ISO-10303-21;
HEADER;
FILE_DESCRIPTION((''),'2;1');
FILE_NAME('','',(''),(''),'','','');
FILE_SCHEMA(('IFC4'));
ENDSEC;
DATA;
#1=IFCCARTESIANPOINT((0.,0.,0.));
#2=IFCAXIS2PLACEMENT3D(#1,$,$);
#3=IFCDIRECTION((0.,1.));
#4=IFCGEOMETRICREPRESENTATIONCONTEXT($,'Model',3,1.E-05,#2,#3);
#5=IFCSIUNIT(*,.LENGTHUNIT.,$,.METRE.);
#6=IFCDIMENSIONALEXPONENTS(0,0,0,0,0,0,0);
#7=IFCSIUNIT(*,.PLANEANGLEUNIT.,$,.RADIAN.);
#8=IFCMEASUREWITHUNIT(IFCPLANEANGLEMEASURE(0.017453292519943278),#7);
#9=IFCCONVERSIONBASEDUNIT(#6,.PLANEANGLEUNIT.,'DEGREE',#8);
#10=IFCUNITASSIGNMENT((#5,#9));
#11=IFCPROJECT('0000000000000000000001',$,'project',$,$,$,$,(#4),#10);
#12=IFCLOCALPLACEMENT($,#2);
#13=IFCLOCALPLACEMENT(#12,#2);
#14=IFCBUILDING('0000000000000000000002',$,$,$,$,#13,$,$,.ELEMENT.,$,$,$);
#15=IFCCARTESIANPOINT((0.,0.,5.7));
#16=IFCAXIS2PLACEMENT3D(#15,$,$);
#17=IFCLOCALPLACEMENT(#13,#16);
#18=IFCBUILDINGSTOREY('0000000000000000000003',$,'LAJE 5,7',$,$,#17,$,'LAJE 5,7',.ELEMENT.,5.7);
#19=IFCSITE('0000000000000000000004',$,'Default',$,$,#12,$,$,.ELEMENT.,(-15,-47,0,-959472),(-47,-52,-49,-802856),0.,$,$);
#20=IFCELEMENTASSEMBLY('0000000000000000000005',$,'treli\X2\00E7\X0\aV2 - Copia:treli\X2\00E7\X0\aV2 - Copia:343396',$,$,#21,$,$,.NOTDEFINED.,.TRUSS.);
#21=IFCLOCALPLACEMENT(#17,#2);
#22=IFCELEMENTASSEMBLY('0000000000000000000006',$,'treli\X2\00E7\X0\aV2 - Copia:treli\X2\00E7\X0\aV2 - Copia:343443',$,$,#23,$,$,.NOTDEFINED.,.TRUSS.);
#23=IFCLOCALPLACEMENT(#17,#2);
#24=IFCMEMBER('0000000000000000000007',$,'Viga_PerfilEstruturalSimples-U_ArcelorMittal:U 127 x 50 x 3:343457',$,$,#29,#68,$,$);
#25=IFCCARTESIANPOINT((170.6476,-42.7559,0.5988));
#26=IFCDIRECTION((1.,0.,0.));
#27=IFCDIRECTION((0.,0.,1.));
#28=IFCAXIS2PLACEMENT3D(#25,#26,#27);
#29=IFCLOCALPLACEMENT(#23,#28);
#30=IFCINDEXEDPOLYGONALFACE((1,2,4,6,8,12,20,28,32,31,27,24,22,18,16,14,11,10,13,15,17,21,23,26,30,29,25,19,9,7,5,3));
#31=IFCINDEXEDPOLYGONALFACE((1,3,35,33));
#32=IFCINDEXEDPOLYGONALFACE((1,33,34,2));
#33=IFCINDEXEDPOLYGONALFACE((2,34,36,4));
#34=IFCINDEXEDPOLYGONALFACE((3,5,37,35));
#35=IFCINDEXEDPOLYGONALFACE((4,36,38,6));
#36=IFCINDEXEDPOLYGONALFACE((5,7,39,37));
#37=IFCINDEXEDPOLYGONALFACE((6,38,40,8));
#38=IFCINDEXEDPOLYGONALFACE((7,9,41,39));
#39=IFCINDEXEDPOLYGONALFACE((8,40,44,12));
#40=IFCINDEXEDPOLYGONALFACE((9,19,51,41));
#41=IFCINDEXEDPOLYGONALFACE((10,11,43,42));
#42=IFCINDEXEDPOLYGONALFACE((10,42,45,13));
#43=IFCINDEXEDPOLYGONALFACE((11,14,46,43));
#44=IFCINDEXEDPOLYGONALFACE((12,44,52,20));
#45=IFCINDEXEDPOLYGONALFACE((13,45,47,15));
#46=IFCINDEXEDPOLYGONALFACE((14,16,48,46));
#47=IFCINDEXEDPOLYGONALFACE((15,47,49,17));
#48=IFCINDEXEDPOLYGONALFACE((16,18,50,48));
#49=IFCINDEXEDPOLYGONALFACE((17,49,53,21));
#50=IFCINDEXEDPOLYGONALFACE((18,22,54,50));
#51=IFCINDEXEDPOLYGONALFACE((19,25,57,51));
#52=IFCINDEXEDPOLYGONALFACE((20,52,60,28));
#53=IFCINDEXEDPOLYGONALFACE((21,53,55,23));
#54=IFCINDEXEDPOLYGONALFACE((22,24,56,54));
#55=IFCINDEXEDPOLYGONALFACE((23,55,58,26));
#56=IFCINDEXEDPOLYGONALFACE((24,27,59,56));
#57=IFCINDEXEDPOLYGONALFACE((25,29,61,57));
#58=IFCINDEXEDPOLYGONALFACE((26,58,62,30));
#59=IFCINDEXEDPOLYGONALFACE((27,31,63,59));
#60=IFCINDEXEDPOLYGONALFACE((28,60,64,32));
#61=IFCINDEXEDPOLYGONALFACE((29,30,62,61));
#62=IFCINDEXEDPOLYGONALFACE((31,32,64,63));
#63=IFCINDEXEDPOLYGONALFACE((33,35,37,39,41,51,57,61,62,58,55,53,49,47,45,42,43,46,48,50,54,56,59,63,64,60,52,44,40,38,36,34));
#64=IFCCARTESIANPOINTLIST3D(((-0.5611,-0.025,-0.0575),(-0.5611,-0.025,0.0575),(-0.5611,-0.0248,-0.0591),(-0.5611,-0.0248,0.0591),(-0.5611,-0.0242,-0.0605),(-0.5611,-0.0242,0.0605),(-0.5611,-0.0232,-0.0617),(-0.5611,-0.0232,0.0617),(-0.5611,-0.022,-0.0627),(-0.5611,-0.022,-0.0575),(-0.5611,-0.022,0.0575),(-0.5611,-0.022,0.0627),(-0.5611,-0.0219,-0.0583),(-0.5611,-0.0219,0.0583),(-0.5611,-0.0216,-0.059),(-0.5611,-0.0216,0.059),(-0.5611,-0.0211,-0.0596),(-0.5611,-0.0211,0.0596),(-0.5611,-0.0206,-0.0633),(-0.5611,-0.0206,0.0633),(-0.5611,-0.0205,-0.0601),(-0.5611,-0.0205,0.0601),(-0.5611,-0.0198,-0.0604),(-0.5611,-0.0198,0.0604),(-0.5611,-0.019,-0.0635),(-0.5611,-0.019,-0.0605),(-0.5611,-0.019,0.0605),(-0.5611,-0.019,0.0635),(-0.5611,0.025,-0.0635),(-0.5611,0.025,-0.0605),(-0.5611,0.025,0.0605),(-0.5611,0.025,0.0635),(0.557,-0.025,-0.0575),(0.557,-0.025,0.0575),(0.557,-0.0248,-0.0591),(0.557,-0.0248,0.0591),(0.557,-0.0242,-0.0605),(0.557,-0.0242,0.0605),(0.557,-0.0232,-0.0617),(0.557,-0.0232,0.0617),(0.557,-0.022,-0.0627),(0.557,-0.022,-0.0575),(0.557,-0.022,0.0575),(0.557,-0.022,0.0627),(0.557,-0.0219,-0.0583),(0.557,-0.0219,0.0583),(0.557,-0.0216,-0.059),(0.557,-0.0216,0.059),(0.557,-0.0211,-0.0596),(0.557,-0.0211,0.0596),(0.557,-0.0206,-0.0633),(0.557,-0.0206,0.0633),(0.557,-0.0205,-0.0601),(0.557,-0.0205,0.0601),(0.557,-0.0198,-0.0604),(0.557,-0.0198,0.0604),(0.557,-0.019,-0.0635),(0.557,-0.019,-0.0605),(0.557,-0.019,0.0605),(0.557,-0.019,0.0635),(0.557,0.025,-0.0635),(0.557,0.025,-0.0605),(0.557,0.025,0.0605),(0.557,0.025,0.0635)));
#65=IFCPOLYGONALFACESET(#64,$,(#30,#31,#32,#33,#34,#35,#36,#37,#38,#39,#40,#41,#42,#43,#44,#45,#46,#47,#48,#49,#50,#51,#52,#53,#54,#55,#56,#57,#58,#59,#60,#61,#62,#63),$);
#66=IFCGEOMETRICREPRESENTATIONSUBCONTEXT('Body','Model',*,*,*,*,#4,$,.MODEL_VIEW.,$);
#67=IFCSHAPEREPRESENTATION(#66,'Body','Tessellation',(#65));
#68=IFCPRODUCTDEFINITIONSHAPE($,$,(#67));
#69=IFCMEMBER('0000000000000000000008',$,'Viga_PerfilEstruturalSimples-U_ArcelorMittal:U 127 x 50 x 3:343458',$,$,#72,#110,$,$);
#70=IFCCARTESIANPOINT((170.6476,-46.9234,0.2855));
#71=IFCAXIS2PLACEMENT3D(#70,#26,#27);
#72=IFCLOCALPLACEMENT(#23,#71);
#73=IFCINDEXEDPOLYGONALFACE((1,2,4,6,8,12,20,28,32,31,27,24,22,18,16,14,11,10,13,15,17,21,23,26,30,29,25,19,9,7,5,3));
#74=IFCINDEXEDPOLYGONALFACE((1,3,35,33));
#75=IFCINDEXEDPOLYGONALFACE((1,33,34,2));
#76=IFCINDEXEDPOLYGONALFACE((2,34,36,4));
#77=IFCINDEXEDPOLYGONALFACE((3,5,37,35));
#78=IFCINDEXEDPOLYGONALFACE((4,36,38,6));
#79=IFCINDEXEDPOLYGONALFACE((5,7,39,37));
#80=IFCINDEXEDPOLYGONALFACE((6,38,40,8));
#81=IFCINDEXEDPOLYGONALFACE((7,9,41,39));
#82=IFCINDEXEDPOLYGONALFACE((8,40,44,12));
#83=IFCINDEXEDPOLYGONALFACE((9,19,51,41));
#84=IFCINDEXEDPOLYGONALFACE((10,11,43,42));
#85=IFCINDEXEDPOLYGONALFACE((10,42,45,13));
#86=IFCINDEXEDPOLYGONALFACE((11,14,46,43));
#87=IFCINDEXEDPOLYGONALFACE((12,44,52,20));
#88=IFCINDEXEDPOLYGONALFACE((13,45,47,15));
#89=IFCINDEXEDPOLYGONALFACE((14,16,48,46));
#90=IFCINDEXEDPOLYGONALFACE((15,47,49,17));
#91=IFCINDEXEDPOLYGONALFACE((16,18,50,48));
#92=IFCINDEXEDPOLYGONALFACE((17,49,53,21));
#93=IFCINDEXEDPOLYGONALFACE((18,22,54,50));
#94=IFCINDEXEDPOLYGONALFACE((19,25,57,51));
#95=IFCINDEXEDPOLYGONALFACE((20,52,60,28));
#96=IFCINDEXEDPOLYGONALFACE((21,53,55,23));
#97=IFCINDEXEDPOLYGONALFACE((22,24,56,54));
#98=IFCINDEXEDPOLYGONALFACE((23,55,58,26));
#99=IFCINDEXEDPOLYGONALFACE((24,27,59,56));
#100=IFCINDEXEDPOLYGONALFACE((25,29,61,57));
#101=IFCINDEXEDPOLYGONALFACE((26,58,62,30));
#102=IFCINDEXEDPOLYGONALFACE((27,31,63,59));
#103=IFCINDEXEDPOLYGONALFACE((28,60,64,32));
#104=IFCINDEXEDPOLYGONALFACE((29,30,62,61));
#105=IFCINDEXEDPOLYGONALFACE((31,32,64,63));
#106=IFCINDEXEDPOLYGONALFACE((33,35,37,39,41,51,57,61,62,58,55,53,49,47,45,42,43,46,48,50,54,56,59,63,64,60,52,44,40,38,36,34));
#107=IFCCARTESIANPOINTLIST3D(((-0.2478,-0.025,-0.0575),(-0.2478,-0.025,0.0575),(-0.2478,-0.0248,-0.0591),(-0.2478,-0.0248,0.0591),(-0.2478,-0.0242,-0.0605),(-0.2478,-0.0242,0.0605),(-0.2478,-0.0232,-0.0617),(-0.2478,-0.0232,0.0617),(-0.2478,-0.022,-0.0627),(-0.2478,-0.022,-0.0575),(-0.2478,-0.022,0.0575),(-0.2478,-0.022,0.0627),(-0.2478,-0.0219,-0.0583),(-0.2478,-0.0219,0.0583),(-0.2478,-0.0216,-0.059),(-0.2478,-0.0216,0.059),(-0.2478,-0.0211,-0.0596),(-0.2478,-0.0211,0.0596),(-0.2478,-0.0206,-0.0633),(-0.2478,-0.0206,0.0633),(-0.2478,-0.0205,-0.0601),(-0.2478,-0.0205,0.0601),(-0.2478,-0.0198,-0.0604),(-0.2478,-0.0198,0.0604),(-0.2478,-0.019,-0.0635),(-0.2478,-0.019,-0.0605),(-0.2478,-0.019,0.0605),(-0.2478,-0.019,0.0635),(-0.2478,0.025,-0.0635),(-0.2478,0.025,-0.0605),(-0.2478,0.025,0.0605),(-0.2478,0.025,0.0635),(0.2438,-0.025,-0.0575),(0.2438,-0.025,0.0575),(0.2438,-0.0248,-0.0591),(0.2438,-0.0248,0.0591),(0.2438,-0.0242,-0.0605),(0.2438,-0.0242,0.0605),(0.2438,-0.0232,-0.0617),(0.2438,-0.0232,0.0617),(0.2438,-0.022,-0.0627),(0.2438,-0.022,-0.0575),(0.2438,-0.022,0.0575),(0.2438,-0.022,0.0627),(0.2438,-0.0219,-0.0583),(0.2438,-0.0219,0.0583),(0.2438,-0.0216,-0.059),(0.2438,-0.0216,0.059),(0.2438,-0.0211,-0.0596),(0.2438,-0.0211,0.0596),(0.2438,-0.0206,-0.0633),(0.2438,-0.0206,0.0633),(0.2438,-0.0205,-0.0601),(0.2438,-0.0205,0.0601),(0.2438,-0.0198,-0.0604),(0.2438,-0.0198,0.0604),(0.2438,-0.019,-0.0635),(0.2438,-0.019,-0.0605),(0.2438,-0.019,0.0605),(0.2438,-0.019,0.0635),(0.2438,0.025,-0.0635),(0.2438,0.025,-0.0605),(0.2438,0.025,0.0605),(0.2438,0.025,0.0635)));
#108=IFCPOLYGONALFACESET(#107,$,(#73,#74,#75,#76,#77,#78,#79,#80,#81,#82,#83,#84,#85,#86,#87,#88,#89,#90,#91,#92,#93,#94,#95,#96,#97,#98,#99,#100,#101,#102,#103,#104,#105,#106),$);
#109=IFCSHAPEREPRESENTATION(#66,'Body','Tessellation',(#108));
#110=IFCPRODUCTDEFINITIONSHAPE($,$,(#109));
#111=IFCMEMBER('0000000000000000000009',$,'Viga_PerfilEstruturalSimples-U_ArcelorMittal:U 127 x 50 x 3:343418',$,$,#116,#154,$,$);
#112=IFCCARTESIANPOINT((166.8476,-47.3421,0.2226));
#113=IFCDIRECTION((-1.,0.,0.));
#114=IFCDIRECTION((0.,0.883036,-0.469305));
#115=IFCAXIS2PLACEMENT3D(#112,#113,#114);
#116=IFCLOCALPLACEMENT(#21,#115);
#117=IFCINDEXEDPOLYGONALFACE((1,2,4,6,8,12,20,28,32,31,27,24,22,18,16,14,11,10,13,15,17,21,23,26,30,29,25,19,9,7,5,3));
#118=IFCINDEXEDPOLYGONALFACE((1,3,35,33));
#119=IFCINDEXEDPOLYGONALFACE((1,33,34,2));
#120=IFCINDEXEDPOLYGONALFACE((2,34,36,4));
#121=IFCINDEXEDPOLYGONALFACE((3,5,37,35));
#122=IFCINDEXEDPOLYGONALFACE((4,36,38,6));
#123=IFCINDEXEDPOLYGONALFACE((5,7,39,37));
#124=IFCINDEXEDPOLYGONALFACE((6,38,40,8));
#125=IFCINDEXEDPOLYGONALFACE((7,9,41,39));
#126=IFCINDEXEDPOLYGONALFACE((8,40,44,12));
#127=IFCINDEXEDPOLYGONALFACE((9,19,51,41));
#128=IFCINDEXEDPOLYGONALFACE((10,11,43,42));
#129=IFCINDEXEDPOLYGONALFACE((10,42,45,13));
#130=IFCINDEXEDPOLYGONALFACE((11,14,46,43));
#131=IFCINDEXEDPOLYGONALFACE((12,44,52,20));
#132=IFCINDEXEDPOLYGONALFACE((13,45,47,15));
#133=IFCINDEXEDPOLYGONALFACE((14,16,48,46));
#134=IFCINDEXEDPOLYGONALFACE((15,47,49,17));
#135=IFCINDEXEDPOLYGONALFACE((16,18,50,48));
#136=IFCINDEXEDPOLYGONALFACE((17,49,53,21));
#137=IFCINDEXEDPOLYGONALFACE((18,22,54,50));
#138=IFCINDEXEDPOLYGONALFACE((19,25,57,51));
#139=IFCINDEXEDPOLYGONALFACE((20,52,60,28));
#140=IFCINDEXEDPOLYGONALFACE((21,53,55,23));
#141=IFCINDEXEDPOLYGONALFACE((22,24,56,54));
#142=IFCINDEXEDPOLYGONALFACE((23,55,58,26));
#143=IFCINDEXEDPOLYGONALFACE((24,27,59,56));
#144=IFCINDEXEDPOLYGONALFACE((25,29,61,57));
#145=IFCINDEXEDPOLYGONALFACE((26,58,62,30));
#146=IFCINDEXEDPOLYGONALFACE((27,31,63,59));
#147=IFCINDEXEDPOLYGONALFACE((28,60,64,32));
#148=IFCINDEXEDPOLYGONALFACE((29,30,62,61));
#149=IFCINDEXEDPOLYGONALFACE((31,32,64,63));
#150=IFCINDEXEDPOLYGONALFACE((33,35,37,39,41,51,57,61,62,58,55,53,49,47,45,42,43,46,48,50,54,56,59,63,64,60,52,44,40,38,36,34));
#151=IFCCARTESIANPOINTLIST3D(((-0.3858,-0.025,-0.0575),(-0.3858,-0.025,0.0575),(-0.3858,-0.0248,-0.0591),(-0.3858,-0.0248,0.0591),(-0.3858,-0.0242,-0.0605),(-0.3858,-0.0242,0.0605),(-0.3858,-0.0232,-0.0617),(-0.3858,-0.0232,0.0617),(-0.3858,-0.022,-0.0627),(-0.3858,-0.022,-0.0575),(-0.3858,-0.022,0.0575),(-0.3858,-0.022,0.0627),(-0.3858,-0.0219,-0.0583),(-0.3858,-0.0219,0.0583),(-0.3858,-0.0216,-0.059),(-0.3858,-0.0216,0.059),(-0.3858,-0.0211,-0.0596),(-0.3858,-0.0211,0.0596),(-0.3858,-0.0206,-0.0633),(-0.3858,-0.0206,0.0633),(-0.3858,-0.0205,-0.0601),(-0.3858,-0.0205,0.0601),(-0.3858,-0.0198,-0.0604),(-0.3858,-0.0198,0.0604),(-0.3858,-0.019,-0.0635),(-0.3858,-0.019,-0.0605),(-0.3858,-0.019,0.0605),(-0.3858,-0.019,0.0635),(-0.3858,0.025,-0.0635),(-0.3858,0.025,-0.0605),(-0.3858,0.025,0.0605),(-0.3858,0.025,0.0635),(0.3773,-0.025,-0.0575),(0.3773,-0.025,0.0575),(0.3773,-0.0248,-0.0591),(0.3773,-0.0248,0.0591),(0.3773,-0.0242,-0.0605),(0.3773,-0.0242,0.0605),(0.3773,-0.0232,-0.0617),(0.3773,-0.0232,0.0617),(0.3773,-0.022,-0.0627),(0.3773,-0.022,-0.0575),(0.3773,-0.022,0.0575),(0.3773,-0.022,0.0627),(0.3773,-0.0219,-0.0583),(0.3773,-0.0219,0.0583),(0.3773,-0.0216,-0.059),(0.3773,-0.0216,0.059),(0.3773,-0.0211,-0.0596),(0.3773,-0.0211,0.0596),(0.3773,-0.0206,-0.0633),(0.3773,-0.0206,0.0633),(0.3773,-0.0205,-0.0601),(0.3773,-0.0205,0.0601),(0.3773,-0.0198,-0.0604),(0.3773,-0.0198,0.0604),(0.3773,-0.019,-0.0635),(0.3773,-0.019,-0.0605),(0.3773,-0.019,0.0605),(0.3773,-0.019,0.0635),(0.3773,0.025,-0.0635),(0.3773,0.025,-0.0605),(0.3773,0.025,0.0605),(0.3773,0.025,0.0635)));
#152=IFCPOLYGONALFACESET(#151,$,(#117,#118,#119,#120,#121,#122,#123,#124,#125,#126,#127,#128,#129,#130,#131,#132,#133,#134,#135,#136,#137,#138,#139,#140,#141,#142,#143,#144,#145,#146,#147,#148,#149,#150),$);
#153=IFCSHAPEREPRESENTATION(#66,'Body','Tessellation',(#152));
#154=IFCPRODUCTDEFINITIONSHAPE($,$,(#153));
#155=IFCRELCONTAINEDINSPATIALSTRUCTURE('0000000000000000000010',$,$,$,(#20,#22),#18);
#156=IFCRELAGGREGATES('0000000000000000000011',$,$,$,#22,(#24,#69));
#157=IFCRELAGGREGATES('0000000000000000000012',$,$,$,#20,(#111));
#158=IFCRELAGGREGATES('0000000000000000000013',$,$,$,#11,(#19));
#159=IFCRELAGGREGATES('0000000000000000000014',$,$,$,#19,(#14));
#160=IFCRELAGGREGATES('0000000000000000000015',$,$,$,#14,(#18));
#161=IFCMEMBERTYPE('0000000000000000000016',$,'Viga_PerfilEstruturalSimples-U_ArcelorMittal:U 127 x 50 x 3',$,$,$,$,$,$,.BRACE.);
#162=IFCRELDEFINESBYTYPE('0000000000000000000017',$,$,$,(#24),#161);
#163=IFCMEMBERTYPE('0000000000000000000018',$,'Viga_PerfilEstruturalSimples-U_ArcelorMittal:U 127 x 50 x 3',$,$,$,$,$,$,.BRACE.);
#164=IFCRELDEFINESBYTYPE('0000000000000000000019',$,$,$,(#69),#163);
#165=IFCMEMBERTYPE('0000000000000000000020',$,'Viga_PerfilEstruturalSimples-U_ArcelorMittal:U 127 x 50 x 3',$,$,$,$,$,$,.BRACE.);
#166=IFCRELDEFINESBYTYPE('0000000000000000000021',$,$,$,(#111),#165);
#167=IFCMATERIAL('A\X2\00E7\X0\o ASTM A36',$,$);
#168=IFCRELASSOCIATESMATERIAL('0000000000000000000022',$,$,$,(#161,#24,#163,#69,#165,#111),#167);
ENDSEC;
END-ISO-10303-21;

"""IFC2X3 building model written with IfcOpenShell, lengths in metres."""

from ifc_helpers import new_model, entity, si_unit, converted_unit, direction, frame, frame_2d, origin, place, context, subcontext, project, spatial, polyline, circle_curve, parameter, trimmed, segment, composite_curve, outline, extrude, source, transform, mapped, material, type_object, type_shapes, element, aggregate, save


model = new_model("IFC2X3")

# Units and contexts
model_context = context("Model", 3, precision=1e-05, world=origin(), true_north=direction((0.0, 1.0)))
body_context = subcontext(model_context, "Body", "Model", "MODEL_VIEW")
ifc_project = project(units=[si_unit("LENGTHUNIT", "METRE"), converted_unit("PLANEANGLEUNIT", "DEGREE", entity("IfcPlaneAngleMeasure", 0.017453292519943278), si_unit("PLANEANGLEUNIT", "RADIAN"), dimensions=[0, 0, 0, 0, 0, 0, 0])], contexts=[model_context])

# Site, building, storey
site_placement = place(None, origin())
site = spatial("IfcSite", under=ifc_project, at=site_placement, Name="Default", CompositionType="ELEMENT", RefLatitude=(-15, -47, 0, -959472), RefLongitude=(-47, -52, -49, -802856), RefElevation=0.0)
building_placement = place(site_placement, origin())
building = spatial("IfcBuilding", under=site, at=building_placement, CompositionType="ELEMENT")
storey_placement = place(building_placement, frame((0.0, 0.0, 5.7)))
storey = spatial("IfcBuildingStorey", under=building, at=storey_placement, Name="LAJE 5,7", LongName="LAJE 5,7", CompositionType="ELEMENT", Elevation=5.7)

# Element assemblies
assembly_1_placement = place(storey_placement, origin())
assembly_1 = element("IfcElementAssembly", 1, at=assembly_1_placement, inside=storey, Name="treliçaV2 - Copia:treliçaV2 - Copia:343396", AssemblyPlace="NOTDEFINED", PredefinedType="TRUSS")
ifc_material = material(Name="Aço ASTM A36")
assembly_2_placement = place(storey_placement, origin())
assembly_2 = element("IfcElementAssembly", 2, at=assembly_2_placement, inside=storey, Name="treliçaV2 - Copia:treliçaV2 - Copia:343443", AssemblyPlace="NOTDEFINED", PredefinedType="TRUSS")

# Members
member_type_1 = type_object("IfcMemberType", Name="Viga_PerfilEstruturalSimples-U_ArcelorMittal:U 127 x 50 x 3", PredefinedType="BRACE", material=ifc_material)
shared_shape_1 = source(origin(), body_context, "Body", "SweptSolid", [
    extrude(outline(composite_curve([segment(polyline([(-0.0575, -0.0192), (0.0575, -0.0192)]), True, "CONTINUOUS"), segment(trimmed(circle_curve(frame_2d((0.0575, -0.0132), x_axis=(0.0, 1.0)), 0.006), [parameter(180.0)], [parameter(270.0)], True, "PARAMETER"), True, "CONTINUOUS"), segment(polyline([(0.0635, -0.0132), (0.0635, 0.0308)]), True, "CONTINUOUS"), segment(polyline([(0.0635, 0.0308), (0.0605, 0.0308)]), True, "CONTINUOUS"), segment(polyline([(0.0605, 0.0308), (0.0605, -0.0132)]), True, "CONTINUOUS"), segment(trimmed(circle_curve(frame_2d((0.0575, -0.0132), x_axis=(0.0, 1.0)), 0.003), [parameter(180.0)], [parameter(270.0)], True, "PARAMETER"), False, "CONTINUOUS"), segment(polyline([(0.0575, -0.0162), (-0.0575, -0.0162)]), True, "CONTINUOUS"), segment(trimmed(circle_curve(frame_2d((-0.0575, -0.0132), x_axis=(0.0, 1.0)), 0.003), [parameter(90.0)], [parameter(180.0)], True, "PARAMETER"), False, "CONTINUOUS"), segment(polyline([(-0.0605, -0.0132), (-0.0605, 0.0308)]), True, "CONTINUOUS"), segment(polyline([(-0.0605, 0.0308), (-0.0635, 0.0308)]), True, "CONTINUOUS"), segment(polyline([(-0.0635, 0.0308), (-0.0635, -0.0132)]), True, "CONTINUOUS"), segment(trimmed(circle_curve(frame_2d((-0.0575, -0.0132), x_axis=(0.0, 1.0)), 0.006), [parameter(90.0)], [parameter(180.0)], True, "PARAMETER"), True, "CONTINUOUS")], self_intersect=False)), frame((-0.5611, -0.0058, 0.0), z_axis=(1.0, 0.0, 0.0), x_axis=(0.0, 0.0, -1.0)), (0.0, 0.0, 1.0), 1.1181),
])
type_shapes(member_type_1, [shared_shape_1])
member_1_placement = place(assembly_2_placement, frame((170.6476, -42.7559, 0.5988), z_axis=(1.0, 0.0, 0.0), x_axis=(0.0, 0.0, 1.0)))
member_1 = element("IfcMember", 3, at=member_1_placement, type_object=member_type_1, material=ifc_material, Name="Viga_PerfilEstruturalSimples-U_ArcelorMittal:U 127 x 50 x 3:343457", context=body_context, shape_type="MappedRepresentation", body=[
    mapped(shared_shape_1, transform((0.0, 0.0, 0.0), scale=1.0)),
])
member_type_2 = type_object("IfcMemberType", Name="Viga_PerfilEstruturalSimples-U_ArcelorMittal:U 127 x 50 x 3", PredefinedType="BRACE", material=ifc_material)
shared_shape_2 = source(origin(), body_context, "Body", "SweptSolid", [
    extrude(outline(composite_curve([segment(polyline([(-0.0575, -0.0192), (0.0575, -0.0192)]), True, "CONTINUOUS"), segment(trimmed(circle_curve(frame_2d((0.0575, -0.0132), x_axis=(0.0, 1.0)), 0.006), [parameter(180.0)], [parameter(270.0)], True, "PARAMETER"), True, "CONTINUOUS"), segment(polyline([(0.0635, -0.0132), (0.0635, 0.0308)]), True, "CONTINUOUS"), segment(polyline([(0.0635, 0.0308), (0.0605, 0.0308)]), True, "CONTINUOUS"), segment(polyline([(0.0605, 0.0308), (0.0605, -0.0132)]), True, "CONTINUOUS"), segment(trimmed(circle_curve(frame_2d((0.0575, -0.0132), x_axis=(0.0, 1.0)), 0.003), [parameter(180.0)], [parameter(270.0)], True, "PARAMETER"), False, "CONTINUOUS"), segment(polyline([(0.0575, -0.0162), (-0.0575, -0.0162)]), True, "CONTINUOUS"), segment(trimmed(circle_curve(frame_2d((-0.0575, -0.0132), x_axis=(0.0, 1.0)), 0.003), [parameter(90.0)], [parameter(180.0)], True, "PARAMETER"), False, "CONTINUOUS"), segment(polyline([(-0.0605, -0.0132), (-0.0605, 0.0308)]), True, "CONTINUOUS"), segment(polyline([(-0.0605, 0.0308), (-0.0635, 0.0308)]), True, "CONTINUOUS"), segment(polyline([(-0.0635, 0.0308), (-0.0635, -0.0132)]), True, "CONTINUOUS"), segment(trimmed(circle_curve(frame_2d((-0.0575, -0.0132), x_axis=(0.0, 1.0)), 0.006), [parameter(90.0)], [parameter(180.0)], True, "PARAMETER"), True, "CONTINUOUS")], self_intersect=False)), frame((-0.2478, -0.0058, 0.0), z_axis=(1.0, 0.0, 0.0), x_axis=(0.0, 0.0, -1.0)), (0.0, 0.0, 1.0), 0.4916),
])
type_shapes(member_type_2, [shared_shape_2])
member_2_placement = place(assembly_2_placement, frame((170.6476, -46.9234, 0.2855), z_axis=(1.0, 0.0, 0.0), x_axis=(0.0, 0.0, 1.0)))
member_2 = element("IfcMember", 4, at=member_2_placement, type_object=member_type_2, material=ifc_material, Name="Viga_PerfilEstruturalSimples-U_ArcelorMittal:U 127 x 50 x 3:343458", context=body_context, shape_type="MappedRepresentation", body=[
    mapped(shared_shape_2, transform((0.0, 0.0, 0.0), scale=1.0)),
])
aggregate(assembly_2, [member_1, member_2])
member_type_3 = type_object("IfcMemberType", Name="Viga_PerfilEstruturalSimples-U_ArcelorMittal:U 127 x 50 x 3", PredefinedType="BRACE", material=ifc_material)
shared_shape_3 = source(origin(), body_context, "Body", "SweptSolid", [
    extrude(outline(composite_curve([segment(polyline([(-0.0575, -0.0192), (0.0575, -0.0192)]), True, "CONTINUOUS"), segment(trimmed(circle_curve(frame_2d((0.0575, -0.0132), x_axis=(0.0, 1.0)), 0.006), [parameter(180.0)], [parameter(270.0)], True, "PARAMETER"), True, "CONTINUOUS"), segment(polyline([(0.0635, -0.0132), (0.0635, 0.0308)]), True, "CONTINUOUS"), segment(polyline([(0.0635, 0.0308), (0.0605, 0.0308)]), True, "CONTINUOUS"), segment(polyline([(0.0605, 0.0308), (0.0605, -0.0132)]), True, "CONTINUOUS"), segment(trimmed(circle_curve(frame_2d((0.0575, -0.0132), x_axis=(0.0, 1.0)), 0.003), [parameter(180.0)], [parameter(270.0)], True, "PARAMETER"), False, "CONTINUOUS"), segment(polyline([(0.0575, -0.0162), (-0.0575, -0.0162)]), True, "CONTINUOUS"), segment(trimmed(circle_curve(frame_2d((-0.0575, -0.0132), x_axis=(0.0, 1.0)), 0.003), [parameter(90.0)], [parameter(180.0)], True, "PARAMETER"), False, "CONTINUOUS"), segment(polyline([(-0.0605, -0.0132), (-0.0605, 0.0308)]), True, "CONTINUOUS"), segment(polyline([(-0.0605, 0.0308), (-0.0635, 0.0308)]), True, "CONTINUOUS"), segment(polyline([(-0.0635, 0.0308), (-0.0635, -0.0132)]), True, "CONTINUOUS"), segment(trimmed(circle_curve(frame_2d((-0.0575, -0.0132), x_axis=(0.0, 1.0)), 0.006), [parameter(90.0)], [parameter(180.0)], True, "PARAMETER"), True, "CONTINUOUS")], self_intersect=False)), frame((-0.3858, -0.0058, 0.0), z_axis=(1.0, 0.0, 0.0), x_axis=(0.0, 0.0, -1.0)), (0.0, 0.0, 1.0), 0.7631),
])
type_shapes(member_type_3, [shared_shape_3])
member_3_placement = place(assembly_1_placement, frame((166.8476, -47.3421, 0.2226), z_axis=(-1.0, 0.0, 0.0), x_axis=(0.0, 0.883036, -0.469305)))
member_3 = element("IfcMember", 5, at=member_3_placement, type_object=member_type_3, material=ifc_material, Name="Viga_PerfilEstruturalSimples-U_ArcelorMittal:U 127 x 50 x 3:343418", context=body_context, shape_type="MappedRepresentation", body=[
    mapped(shared_shape_3, transform((0.0, 0.0, 0.0), scale=1.0)),
])
aggregate(assembly_1, [member_3])

save(model, "model.ifc")
